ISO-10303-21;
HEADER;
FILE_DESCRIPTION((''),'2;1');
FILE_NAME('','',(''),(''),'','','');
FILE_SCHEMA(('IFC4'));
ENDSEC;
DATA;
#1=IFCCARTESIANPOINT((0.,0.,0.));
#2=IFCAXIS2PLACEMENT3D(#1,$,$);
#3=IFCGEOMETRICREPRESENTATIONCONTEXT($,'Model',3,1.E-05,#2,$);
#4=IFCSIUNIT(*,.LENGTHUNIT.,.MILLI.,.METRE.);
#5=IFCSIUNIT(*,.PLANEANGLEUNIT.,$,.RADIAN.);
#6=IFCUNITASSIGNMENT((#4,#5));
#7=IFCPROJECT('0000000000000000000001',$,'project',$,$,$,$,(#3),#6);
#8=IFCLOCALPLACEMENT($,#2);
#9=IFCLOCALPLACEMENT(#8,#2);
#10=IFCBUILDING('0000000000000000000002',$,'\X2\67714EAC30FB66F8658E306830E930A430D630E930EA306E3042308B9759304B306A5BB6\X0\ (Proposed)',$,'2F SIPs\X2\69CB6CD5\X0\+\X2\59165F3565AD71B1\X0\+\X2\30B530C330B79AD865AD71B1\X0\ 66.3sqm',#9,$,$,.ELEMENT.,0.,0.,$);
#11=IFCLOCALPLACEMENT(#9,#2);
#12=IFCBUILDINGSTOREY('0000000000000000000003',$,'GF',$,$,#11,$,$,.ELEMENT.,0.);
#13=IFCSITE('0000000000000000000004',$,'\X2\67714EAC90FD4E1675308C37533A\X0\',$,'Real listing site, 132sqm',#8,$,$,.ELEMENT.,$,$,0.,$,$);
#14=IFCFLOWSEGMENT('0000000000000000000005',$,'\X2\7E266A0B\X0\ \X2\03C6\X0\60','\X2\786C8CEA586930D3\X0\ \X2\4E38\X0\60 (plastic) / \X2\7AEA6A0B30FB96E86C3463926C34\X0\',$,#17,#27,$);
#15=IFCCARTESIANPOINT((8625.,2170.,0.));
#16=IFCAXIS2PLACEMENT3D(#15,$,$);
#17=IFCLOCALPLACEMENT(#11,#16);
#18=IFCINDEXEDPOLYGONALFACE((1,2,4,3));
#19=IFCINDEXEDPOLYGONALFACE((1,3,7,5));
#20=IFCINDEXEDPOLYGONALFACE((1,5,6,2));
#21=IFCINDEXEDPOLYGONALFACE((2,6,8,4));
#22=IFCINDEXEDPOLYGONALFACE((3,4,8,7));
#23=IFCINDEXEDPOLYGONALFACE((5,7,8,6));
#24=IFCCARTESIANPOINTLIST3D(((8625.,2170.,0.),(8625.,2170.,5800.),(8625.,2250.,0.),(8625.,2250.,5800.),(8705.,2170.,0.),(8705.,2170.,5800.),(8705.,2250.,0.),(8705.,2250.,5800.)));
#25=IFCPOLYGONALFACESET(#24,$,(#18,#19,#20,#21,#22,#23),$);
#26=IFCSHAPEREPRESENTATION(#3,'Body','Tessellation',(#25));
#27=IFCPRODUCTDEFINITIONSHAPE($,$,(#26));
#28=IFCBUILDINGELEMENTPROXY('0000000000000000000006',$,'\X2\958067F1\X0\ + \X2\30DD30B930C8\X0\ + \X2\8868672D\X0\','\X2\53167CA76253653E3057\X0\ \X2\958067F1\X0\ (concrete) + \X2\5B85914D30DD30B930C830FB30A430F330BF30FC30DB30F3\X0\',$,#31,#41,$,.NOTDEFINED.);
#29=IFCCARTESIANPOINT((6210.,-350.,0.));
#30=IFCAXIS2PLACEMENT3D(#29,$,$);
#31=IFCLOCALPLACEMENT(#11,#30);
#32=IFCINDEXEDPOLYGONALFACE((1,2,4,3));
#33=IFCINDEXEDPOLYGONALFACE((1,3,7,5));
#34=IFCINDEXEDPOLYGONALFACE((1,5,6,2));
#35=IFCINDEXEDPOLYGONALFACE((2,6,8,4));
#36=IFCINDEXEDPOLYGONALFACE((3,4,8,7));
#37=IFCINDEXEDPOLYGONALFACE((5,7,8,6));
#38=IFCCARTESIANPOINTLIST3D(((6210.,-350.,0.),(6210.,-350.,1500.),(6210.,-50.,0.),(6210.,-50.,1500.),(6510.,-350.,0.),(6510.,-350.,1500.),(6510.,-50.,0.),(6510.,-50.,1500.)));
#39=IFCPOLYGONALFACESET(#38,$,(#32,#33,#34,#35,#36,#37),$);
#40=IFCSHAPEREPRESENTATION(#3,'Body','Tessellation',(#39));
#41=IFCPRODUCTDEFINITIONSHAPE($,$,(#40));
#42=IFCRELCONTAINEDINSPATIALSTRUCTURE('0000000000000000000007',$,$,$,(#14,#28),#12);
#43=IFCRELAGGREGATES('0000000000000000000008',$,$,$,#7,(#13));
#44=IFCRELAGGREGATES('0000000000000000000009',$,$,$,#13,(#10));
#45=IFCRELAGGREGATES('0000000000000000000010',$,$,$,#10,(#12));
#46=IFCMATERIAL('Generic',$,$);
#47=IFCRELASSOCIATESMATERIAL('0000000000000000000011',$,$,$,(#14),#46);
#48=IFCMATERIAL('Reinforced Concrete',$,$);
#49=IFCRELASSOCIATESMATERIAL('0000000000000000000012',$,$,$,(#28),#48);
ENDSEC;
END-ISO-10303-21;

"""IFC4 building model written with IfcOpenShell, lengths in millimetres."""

from ifc_helpers import new_model, si_unit, frame, frame_2d, origin, place, context, project, spatial, rectangle, extrude, material, element, save


model = new_model("IFC4")

# Units and contexts
model_context = context("Model", 3, precision=1e-05, world=origin())
ifc_project = project(units=[si_unit("LENGTHUNIT", "METRE", prefix="MILLI"), si_unit("PLANEANGLEUNIT", "RADIAN")], contexts=[model_context])

# Site, building, storey
site_placement = place(None, origin())
site = spatial("IfcSite", under=ifc_project, at=site_placement, Name="東京都世田谷区", ObjectType="Real listing site, 132sqm", CompositionType="ELEMENT", RefElevation=0.0)
building_placement = place(site_placement, origin())
building = spatial("IfcBuilding", under=site, at=building_placement, Name="東京・書斎とライブラリのある静かな家 (Proposed)", ObjectType="2F SIPs構法+外張断熱+サッシ高断熱 66.3sqm", CompositionType="ELEMENT", ElevationOfRefHeight=0.0, ElevationOfTerrain=0.0)
storey_placement = place(building_placement, origin())
storey = spatial("IfcBuildingStorey", under=building, at=storey_placement, Name="GF", CompositionType="ELEMENT", Elevation=0.0)

# Shared definitions
ifc_material_1 = material(Name="Reinforced Concrete")

# Flow segment
ifc_material_2 = material(Name="Generic")
flow_segment_1_placement = place(storey_placement, frame((8625.0, 2170.0, 0.0)))
element("IfcFlowSegment", 1, at=flow_segment_1_placement, inside=storey, material=ifc_material_2, Name="縦樋 φ60", Description="硬質塩ビ 丸60 (plastic) / 竪樋・雨水排水", context=model_context, shape_type="SweptSolid", body=[
    extrude(rectangle(XDim=80.0, YDim=80.0, at=frame_2d((40.0, 40.0))), frame((8625.0, 2170.0, 0.0)), (0.0, 0.0, 1.0), 5800.0),
])

# Building element proxy
proxy_placement = place(storey_placement, frame((6210.0, -350.0, 0.0)))
element("IfcBuildingElementProxy", 2, at=proxy_placement, inside=storey, material=ifc_material_1, Name="門柱 + ポスト + 表札", Description="化粧打放し 門柱 (concrete) + 宅配ポスト・インターホン", PredefinedType="NOTDEFINED", context=model_context, shape_type="SweptSolid", body=[
    extrude(rectangle(XDim=300.0, YDim=300.0, at=frame_2d((150.0, 150.0))), frame((6210.0, -350.0, 0.0)), (0.0, 0.0, 1.0), 1500.0),
])

save(model, "model.ifc")
